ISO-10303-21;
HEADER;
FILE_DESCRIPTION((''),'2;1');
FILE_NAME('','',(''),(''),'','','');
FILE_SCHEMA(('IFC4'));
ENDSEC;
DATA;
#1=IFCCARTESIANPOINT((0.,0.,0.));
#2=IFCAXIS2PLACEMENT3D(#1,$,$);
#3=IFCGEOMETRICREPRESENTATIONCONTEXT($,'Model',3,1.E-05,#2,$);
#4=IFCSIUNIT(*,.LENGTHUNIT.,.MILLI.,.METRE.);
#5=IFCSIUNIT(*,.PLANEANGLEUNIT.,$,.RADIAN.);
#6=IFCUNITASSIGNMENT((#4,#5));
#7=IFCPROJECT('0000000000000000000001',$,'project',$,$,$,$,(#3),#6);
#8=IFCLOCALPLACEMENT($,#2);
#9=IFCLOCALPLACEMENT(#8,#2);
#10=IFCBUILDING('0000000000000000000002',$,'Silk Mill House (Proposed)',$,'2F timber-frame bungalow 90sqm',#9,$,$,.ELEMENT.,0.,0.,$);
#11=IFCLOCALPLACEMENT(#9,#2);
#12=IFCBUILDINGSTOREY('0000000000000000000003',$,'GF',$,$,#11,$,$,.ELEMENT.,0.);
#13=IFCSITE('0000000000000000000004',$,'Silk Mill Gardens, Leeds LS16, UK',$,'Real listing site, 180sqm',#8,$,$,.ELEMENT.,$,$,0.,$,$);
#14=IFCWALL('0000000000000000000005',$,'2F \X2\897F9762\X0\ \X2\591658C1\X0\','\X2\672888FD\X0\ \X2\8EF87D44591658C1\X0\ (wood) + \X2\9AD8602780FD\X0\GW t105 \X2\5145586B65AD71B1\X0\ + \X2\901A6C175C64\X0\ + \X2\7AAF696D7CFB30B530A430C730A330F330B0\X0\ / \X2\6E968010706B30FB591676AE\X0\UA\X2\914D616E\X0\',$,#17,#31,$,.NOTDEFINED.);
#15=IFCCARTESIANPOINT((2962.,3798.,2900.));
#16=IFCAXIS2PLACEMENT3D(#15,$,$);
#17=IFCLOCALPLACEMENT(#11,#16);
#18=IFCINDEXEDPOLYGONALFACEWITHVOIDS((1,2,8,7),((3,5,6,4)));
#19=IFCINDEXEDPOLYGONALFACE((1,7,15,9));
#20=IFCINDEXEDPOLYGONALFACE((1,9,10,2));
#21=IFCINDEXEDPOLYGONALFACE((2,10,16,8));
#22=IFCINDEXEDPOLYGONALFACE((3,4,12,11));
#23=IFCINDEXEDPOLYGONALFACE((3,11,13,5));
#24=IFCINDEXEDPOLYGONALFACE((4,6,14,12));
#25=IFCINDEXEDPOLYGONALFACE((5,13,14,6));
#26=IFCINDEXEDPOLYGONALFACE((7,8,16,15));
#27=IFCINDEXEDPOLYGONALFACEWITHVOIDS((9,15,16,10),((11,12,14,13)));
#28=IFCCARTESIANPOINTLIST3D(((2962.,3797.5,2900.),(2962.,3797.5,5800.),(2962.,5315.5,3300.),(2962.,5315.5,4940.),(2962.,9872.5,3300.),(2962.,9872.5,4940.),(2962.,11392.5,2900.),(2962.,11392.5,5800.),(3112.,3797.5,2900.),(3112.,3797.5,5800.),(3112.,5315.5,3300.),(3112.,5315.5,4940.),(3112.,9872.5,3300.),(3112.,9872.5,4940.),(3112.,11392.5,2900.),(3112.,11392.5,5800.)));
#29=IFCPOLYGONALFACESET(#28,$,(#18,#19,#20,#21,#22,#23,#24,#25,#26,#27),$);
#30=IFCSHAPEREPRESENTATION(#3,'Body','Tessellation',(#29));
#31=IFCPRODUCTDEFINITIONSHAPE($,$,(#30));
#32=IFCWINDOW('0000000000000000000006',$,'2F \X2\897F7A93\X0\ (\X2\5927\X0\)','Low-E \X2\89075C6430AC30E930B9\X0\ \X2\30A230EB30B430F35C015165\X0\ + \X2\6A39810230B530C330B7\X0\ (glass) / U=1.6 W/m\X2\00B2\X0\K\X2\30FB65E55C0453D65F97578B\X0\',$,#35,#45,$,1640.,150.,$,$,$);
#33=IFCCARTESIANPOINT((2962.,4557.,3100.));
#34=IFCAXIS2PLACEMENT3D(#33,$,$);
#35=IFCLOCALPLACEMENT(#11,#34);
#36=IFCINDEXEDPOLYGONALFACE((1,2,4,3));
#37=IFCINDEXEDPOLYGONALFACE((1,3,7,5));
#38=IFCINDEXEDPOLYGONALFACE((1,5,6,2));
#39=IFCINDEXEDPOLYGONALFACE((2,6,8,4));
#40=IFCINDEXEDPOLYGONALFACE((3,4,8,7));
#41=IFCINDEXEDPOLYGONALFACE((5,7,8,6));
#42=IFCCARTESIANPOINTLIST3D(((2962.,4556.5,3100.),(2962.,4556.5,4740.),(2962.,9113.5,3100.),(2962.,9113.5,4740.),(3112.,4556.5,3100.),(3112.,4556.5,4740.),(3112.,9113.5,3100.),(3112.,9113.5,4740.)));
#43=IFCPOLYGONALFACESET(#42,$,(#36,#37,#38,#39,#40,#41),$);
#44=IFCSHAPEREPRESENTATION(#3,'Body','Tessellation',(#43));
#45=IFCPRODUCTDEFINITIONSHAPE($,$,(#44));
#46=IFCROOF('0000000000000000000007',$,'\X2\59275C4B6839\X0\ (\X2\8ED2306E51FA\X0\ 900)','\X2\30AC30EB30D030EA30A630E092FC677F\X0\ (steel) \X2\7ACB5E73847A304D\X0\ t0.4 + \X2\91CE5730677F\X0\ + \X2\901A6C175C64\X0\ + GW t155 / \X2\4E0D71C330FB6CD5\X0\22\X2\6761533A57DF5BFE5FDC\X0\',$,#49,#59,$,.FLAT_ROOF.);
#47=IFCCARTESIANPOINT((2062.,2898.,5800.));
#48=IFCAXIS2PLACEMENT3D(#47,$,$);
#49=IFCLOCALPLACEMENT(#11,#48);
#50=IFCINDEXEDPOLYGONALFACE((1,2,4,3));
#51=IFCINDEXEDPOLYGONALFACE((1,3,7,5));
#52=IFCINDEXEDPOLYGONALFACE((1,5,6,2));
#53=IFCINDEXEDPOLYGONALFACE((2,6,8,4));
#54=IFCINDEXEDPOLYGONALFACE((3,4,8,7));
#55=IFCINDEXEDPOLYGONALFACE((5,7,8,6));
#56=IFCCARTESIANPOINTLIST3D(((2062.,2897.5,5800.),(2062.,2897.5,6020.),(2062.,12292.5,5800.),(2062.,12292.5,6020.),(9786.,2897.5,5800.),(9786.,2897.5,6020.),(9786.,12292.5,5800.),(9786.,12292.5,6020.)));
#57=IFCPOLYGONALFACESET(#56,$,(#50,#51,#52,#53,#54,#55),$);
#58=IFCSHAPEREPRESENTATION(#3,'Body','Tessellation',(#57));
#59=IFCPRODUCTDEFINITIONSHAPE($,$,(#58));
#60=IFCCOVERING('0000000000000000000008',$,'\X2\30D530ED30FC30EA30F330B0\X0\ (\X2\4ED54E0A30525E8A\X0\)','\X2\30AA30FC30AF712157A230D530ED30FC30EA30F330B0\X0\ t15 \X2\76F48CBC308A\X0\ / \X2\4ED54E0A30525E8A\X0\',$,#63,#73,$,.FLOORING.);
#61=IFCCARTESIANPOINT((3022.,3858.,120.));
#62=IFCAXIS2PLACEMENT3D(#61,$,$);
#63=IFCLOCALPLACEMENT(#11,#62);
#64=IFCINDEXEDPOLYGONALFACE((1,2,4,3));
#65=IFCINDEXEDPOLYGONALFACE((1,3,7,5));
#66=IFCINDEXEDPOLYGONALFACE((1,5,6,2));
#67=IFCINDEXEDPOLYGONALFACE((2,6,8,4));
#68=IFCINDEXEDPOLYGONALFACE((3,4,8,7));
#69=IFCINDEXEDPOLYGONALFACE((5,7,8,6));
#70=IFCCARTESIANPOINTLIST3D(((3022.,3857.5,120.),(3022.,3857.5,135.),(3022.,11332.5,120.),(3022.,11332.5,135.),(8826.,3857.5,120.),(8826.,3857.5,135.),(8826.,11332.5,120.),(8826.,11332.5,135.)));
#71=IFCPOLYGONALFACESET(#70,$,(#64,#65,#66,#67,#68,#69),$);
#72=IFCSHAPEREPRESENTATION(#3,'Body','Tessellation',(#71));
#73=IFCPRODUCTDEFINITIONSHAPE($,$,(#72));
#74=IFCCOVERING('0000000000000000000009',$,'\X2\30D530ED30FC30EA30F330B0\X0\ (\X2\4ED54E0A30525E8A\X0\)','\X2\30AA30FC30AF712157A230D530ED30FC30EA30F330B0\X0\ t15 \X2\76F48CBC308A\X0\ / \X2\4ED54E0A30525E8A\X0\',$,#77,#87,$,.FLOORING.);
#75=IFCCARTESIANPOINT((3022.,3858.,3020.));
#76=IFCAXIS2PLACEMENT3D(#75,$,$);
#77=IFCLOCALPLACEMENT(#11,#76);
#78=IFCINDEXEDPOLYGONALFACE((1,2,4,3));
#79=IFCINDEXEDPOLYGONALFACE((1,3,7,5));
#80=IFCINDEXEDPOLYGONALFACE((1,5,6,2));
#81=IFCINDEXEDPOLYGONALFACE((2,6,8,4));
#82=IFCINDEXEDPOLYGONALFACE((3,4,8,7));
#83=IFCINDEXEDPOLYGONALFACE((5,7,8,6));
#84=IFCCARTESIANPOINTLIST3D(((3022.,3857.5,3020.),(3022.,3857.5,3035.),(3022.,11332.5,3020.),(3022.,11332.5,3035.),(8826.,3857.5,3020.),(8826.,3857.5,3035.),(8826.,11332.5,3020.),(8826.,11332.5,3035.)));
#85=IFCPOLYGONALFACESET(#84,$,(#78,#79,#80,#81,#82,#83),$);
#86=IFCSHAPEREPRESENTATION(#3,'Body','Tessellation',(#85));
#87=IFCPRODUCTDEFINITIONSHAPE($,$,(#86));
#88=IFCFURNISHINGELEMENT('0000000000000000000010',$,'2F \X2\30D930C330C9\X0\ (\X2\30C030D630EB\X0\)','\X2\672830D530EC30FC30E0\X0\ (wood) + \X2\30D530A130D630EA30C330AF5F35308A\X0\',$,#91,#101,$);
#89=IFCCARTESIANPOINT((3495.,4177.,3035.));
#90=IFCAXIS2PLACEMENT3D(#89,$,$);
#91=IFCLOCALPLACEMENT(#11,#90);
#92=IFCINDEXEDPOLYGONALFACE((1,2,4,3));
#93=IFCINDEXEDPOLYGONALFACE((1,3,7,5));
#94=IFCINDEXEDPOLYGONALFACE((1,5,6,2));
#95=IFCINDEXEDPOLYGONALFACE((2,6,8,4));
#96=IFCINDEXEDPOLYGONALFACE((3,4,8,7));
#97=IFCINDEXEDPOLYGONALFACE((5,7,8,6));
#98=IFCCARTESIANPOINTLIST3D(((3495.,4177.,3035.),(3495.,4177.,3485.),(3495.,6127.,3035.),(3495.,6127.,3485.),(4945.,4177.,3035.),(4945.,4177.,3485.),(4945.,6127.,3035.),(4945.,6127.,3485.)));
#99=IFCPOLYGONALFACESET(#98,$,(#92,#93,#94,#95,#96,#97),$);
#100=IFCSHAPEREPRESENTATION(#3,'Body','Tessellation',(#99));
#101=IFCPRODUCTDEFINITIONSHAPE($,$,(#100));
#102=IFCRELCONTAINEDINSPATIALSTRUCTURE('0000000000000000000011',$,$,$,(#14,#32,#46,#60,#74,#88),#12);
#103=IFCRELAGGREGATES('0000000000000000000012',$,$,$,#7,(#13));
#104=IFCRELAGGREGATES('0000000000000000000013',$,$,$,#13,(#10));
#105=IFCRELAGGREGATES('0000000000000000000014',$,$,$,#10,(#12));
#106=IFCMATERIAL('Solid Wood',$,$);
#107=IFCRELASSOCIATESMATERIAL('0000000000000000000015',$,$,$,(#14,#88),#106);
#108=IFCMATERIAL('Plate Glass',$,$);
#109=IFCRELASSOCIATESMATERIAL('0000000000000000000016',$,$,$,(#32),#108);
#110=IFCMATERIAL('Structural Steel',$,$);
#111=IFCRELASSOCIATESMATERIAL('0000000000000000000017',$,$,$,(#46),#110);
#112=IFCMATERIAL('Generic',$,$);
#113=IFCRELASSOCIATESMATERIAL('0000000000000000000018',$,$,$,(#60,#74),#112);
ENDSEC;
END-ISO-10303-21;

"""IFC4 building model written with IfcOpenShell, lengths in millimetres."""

from ifc_helpers import new_model, si_unit, frame, frame_2d, origin, place, context, project, spatial, rectangle, extrude, material, element, fill, save


model = new_model("IFC4")

# Units and contexts
model_context = context("Model", 3, precision=1e-05, world=origin())
ifc_project = project(units=[si_unit("LENGTHUNIT", "METRE", prefix="MILLI"), si_unit("PLANEANGLEUNIT", "RADIAN")], contexts=[model_context])

# Site, building, storey
site_placement = place(None, origin())
site = spatial("IfcSite", under=ifc_project, at=site_placement, Name="Silk Mill Gardens, Leeds LS16, UK", ObjectType="Real listing site, 180sqm", CompositionType="ELEMENT", RefElevation=0.0)
building_placement = place(site_placement, origin())
building = spatial("IfcBuilding", under=site, at=building_placement, Name="Silk Mill House (Proposed)", ObjectType="2F timber-frame bungalow 90sqm", CompositionType="ELEMENT", ElevationOfRefHeight=0.0, ElevationOfTerrain=0.0)
storey_placement = place(building_placement, origin())
storey = spatial("IfcBuildingStorey", under=building, at=storey_placement, Name="GF", CompositionType="ELEMENT", Elevation=0.0)

# Shared definitions
ifc_material_1 = material(Name="Solid Wood")

# Shared definitions
ifc_material_2 = material(Name="Plate Glass")

# Wall, opening, window
wall_1_placement = place(storey_placement, frame((2962.0, 3798.0, 2900.0)))
wall_1 = element("IfcWall", 1, at=wall_1_placement, inside=storey, material=ifc_material_1, Name="2F 西面 外壁", Description="木製 軸組外壁 (wood) + 高性能GW t105 充填断熱 + 通気層 + 窯業系サイディング / 準耐火・外皮UA配慮", PredefinedType="NOTDEFINED", context=model_context, shape_type="SweptSolid", body=[
    extrude(rectangle(XDim=150.0, YDim=7595.0, at=frame_2d((75.0, 3797.0))), frame((2962.0, 3798.0, 2900.0)), (0.0, 0.0, 1.0), 2900.0),
])
opening_1_placement = place(storey_placement, frame((2962.0, 4557.0, 3100.0)))
opening_1 = element("IfcOpeningElement", 2, at=opening_1_placement, cuts=wall_1, PredefinedType="NOTDEFINED", context=model_context, shape_type="SweptSolid", body=[
    extrude(rectangle(XDim=150.0, YDim=4557.0, at=frame_2d((75.0, 2278.0))), frame((2962.0, 4557.0, 3100.0)), (0.0, 0.0, 1.0), 1640.0),
])
window_1_placement = place(storey_placement, frame((2962.0, 4557.0, 3100.0)))
window_1 = element("IfcWindow", 3, at=window_1_placement, inside=storey, material=ifc_material_2, Name="2F 西窓 (大)", Description="Low-E 複層ガラス アルゴン封入 + 樹脂サッシ (glass) / U=1.6 W/m²K・日射取得型", OverallHeight=1640.0, OverallWidth=150.0, context=model_context, shape_type="SweptSolid", body=[
    extrude(rectangle(XDim=150.0, YDim=4557.0, at=frame_2d((75.0, 2278.0))), frame((2962.0, 4557.0, 3100.0)), (0.0, 0.0, 1.0), 1640.0),
])
fill(opening_1, window_1)

# Roof
ifc_material_3 = material(Name="Structural Steel")
roof_placement = place(storey_placement, frame((2062.0, 2898.0, 5800.0)))
element("IfcRoof", 4, at=roof_placement, inside=storey, material=ifc_material_3, Name="大屋根 (軒の出 900)", Description="ガルバリウム鋼板 (steel) 立平葺き t0.4 + 野地板 + 通気層 + GW t155 / 不燃・法22条区域対応", PredefinedType="FLAT_ROOF", context=model_context, shape_type="SweptSolid", body=[
    extrude(rectangle(XDim=7724.0, YDim=9395.0, at=frame_2d((3862.0, 4697.0))), frame((2062.0, 2898.0, 5800.0)), (0.0, 0.0, 1.0), 220.0),
])

# Coverings
ifc_material_4 = material(Name="Generic")
covering_1_placement = place(storey_placement, frame((3022.0, 3858.0, 120.0)))
element("IfcCovering", 5, at=covering_1_placement, inside=storey, material=ifc_material_4, Name="フローリング (仕上げ床)", Description="オーク無垢フローリング t15 直貼り / 仕上げ床", PredefinedType="FLOORING", context=model_context, shape_type="SweptSolid", body=[
    extrude(rectangle(XDim=5804.0, YDim=7475.0, at=frame_2d((2902.0, 3737.0))), frame((3022.0, 3858.0, 120.0)), (0.0, 0.0, 1.0), 15.0),
])
covering_2_placement = place(storey_placement, frame((3022.0, 3858.0, 3020.0)))
element("IfcCovering", 6, at=covering_2_placement, inside=storey, material=ifc_material_4, Name="フローリング (仕上げ床)", Description="オーク無垢フローリング t15 直貼り / 仕上げ床", PredefinedType="FLOORING", context=model_context, shape_type="SweptSolid", body=[
    extrude(rectangle(XDim=5804.0, YDim=7475.0, at=frame_2d((2902.0, 3737.0))), frame((3022.0, 3858.0, 3020.0)), (0.0, 0.0, 1.0), 15.0),
])

# Furnishing element
furnishing_placement = place(storey_placement, frame((3495.0, 4177.0, 3035.0)))
element("IfcFurnishingElement", 7, at=furnishing_placement, inside=storey, material=ifc_material_1, Name="2F ベッド (ダブル)", Description="木フレーム (wood) + ファブリック張り", context=model_context, shape_type="SweptSolid", body=[
    extrude(rectangle(XDim=1450.0, YDim=1950.0, at=frame_2d((725.0, 975.0))), frame((3495.0, 4177.0, 3035.0)), (0.0, 0.0, 1.0), 450.0),
])

save(model, "model.ifc")
